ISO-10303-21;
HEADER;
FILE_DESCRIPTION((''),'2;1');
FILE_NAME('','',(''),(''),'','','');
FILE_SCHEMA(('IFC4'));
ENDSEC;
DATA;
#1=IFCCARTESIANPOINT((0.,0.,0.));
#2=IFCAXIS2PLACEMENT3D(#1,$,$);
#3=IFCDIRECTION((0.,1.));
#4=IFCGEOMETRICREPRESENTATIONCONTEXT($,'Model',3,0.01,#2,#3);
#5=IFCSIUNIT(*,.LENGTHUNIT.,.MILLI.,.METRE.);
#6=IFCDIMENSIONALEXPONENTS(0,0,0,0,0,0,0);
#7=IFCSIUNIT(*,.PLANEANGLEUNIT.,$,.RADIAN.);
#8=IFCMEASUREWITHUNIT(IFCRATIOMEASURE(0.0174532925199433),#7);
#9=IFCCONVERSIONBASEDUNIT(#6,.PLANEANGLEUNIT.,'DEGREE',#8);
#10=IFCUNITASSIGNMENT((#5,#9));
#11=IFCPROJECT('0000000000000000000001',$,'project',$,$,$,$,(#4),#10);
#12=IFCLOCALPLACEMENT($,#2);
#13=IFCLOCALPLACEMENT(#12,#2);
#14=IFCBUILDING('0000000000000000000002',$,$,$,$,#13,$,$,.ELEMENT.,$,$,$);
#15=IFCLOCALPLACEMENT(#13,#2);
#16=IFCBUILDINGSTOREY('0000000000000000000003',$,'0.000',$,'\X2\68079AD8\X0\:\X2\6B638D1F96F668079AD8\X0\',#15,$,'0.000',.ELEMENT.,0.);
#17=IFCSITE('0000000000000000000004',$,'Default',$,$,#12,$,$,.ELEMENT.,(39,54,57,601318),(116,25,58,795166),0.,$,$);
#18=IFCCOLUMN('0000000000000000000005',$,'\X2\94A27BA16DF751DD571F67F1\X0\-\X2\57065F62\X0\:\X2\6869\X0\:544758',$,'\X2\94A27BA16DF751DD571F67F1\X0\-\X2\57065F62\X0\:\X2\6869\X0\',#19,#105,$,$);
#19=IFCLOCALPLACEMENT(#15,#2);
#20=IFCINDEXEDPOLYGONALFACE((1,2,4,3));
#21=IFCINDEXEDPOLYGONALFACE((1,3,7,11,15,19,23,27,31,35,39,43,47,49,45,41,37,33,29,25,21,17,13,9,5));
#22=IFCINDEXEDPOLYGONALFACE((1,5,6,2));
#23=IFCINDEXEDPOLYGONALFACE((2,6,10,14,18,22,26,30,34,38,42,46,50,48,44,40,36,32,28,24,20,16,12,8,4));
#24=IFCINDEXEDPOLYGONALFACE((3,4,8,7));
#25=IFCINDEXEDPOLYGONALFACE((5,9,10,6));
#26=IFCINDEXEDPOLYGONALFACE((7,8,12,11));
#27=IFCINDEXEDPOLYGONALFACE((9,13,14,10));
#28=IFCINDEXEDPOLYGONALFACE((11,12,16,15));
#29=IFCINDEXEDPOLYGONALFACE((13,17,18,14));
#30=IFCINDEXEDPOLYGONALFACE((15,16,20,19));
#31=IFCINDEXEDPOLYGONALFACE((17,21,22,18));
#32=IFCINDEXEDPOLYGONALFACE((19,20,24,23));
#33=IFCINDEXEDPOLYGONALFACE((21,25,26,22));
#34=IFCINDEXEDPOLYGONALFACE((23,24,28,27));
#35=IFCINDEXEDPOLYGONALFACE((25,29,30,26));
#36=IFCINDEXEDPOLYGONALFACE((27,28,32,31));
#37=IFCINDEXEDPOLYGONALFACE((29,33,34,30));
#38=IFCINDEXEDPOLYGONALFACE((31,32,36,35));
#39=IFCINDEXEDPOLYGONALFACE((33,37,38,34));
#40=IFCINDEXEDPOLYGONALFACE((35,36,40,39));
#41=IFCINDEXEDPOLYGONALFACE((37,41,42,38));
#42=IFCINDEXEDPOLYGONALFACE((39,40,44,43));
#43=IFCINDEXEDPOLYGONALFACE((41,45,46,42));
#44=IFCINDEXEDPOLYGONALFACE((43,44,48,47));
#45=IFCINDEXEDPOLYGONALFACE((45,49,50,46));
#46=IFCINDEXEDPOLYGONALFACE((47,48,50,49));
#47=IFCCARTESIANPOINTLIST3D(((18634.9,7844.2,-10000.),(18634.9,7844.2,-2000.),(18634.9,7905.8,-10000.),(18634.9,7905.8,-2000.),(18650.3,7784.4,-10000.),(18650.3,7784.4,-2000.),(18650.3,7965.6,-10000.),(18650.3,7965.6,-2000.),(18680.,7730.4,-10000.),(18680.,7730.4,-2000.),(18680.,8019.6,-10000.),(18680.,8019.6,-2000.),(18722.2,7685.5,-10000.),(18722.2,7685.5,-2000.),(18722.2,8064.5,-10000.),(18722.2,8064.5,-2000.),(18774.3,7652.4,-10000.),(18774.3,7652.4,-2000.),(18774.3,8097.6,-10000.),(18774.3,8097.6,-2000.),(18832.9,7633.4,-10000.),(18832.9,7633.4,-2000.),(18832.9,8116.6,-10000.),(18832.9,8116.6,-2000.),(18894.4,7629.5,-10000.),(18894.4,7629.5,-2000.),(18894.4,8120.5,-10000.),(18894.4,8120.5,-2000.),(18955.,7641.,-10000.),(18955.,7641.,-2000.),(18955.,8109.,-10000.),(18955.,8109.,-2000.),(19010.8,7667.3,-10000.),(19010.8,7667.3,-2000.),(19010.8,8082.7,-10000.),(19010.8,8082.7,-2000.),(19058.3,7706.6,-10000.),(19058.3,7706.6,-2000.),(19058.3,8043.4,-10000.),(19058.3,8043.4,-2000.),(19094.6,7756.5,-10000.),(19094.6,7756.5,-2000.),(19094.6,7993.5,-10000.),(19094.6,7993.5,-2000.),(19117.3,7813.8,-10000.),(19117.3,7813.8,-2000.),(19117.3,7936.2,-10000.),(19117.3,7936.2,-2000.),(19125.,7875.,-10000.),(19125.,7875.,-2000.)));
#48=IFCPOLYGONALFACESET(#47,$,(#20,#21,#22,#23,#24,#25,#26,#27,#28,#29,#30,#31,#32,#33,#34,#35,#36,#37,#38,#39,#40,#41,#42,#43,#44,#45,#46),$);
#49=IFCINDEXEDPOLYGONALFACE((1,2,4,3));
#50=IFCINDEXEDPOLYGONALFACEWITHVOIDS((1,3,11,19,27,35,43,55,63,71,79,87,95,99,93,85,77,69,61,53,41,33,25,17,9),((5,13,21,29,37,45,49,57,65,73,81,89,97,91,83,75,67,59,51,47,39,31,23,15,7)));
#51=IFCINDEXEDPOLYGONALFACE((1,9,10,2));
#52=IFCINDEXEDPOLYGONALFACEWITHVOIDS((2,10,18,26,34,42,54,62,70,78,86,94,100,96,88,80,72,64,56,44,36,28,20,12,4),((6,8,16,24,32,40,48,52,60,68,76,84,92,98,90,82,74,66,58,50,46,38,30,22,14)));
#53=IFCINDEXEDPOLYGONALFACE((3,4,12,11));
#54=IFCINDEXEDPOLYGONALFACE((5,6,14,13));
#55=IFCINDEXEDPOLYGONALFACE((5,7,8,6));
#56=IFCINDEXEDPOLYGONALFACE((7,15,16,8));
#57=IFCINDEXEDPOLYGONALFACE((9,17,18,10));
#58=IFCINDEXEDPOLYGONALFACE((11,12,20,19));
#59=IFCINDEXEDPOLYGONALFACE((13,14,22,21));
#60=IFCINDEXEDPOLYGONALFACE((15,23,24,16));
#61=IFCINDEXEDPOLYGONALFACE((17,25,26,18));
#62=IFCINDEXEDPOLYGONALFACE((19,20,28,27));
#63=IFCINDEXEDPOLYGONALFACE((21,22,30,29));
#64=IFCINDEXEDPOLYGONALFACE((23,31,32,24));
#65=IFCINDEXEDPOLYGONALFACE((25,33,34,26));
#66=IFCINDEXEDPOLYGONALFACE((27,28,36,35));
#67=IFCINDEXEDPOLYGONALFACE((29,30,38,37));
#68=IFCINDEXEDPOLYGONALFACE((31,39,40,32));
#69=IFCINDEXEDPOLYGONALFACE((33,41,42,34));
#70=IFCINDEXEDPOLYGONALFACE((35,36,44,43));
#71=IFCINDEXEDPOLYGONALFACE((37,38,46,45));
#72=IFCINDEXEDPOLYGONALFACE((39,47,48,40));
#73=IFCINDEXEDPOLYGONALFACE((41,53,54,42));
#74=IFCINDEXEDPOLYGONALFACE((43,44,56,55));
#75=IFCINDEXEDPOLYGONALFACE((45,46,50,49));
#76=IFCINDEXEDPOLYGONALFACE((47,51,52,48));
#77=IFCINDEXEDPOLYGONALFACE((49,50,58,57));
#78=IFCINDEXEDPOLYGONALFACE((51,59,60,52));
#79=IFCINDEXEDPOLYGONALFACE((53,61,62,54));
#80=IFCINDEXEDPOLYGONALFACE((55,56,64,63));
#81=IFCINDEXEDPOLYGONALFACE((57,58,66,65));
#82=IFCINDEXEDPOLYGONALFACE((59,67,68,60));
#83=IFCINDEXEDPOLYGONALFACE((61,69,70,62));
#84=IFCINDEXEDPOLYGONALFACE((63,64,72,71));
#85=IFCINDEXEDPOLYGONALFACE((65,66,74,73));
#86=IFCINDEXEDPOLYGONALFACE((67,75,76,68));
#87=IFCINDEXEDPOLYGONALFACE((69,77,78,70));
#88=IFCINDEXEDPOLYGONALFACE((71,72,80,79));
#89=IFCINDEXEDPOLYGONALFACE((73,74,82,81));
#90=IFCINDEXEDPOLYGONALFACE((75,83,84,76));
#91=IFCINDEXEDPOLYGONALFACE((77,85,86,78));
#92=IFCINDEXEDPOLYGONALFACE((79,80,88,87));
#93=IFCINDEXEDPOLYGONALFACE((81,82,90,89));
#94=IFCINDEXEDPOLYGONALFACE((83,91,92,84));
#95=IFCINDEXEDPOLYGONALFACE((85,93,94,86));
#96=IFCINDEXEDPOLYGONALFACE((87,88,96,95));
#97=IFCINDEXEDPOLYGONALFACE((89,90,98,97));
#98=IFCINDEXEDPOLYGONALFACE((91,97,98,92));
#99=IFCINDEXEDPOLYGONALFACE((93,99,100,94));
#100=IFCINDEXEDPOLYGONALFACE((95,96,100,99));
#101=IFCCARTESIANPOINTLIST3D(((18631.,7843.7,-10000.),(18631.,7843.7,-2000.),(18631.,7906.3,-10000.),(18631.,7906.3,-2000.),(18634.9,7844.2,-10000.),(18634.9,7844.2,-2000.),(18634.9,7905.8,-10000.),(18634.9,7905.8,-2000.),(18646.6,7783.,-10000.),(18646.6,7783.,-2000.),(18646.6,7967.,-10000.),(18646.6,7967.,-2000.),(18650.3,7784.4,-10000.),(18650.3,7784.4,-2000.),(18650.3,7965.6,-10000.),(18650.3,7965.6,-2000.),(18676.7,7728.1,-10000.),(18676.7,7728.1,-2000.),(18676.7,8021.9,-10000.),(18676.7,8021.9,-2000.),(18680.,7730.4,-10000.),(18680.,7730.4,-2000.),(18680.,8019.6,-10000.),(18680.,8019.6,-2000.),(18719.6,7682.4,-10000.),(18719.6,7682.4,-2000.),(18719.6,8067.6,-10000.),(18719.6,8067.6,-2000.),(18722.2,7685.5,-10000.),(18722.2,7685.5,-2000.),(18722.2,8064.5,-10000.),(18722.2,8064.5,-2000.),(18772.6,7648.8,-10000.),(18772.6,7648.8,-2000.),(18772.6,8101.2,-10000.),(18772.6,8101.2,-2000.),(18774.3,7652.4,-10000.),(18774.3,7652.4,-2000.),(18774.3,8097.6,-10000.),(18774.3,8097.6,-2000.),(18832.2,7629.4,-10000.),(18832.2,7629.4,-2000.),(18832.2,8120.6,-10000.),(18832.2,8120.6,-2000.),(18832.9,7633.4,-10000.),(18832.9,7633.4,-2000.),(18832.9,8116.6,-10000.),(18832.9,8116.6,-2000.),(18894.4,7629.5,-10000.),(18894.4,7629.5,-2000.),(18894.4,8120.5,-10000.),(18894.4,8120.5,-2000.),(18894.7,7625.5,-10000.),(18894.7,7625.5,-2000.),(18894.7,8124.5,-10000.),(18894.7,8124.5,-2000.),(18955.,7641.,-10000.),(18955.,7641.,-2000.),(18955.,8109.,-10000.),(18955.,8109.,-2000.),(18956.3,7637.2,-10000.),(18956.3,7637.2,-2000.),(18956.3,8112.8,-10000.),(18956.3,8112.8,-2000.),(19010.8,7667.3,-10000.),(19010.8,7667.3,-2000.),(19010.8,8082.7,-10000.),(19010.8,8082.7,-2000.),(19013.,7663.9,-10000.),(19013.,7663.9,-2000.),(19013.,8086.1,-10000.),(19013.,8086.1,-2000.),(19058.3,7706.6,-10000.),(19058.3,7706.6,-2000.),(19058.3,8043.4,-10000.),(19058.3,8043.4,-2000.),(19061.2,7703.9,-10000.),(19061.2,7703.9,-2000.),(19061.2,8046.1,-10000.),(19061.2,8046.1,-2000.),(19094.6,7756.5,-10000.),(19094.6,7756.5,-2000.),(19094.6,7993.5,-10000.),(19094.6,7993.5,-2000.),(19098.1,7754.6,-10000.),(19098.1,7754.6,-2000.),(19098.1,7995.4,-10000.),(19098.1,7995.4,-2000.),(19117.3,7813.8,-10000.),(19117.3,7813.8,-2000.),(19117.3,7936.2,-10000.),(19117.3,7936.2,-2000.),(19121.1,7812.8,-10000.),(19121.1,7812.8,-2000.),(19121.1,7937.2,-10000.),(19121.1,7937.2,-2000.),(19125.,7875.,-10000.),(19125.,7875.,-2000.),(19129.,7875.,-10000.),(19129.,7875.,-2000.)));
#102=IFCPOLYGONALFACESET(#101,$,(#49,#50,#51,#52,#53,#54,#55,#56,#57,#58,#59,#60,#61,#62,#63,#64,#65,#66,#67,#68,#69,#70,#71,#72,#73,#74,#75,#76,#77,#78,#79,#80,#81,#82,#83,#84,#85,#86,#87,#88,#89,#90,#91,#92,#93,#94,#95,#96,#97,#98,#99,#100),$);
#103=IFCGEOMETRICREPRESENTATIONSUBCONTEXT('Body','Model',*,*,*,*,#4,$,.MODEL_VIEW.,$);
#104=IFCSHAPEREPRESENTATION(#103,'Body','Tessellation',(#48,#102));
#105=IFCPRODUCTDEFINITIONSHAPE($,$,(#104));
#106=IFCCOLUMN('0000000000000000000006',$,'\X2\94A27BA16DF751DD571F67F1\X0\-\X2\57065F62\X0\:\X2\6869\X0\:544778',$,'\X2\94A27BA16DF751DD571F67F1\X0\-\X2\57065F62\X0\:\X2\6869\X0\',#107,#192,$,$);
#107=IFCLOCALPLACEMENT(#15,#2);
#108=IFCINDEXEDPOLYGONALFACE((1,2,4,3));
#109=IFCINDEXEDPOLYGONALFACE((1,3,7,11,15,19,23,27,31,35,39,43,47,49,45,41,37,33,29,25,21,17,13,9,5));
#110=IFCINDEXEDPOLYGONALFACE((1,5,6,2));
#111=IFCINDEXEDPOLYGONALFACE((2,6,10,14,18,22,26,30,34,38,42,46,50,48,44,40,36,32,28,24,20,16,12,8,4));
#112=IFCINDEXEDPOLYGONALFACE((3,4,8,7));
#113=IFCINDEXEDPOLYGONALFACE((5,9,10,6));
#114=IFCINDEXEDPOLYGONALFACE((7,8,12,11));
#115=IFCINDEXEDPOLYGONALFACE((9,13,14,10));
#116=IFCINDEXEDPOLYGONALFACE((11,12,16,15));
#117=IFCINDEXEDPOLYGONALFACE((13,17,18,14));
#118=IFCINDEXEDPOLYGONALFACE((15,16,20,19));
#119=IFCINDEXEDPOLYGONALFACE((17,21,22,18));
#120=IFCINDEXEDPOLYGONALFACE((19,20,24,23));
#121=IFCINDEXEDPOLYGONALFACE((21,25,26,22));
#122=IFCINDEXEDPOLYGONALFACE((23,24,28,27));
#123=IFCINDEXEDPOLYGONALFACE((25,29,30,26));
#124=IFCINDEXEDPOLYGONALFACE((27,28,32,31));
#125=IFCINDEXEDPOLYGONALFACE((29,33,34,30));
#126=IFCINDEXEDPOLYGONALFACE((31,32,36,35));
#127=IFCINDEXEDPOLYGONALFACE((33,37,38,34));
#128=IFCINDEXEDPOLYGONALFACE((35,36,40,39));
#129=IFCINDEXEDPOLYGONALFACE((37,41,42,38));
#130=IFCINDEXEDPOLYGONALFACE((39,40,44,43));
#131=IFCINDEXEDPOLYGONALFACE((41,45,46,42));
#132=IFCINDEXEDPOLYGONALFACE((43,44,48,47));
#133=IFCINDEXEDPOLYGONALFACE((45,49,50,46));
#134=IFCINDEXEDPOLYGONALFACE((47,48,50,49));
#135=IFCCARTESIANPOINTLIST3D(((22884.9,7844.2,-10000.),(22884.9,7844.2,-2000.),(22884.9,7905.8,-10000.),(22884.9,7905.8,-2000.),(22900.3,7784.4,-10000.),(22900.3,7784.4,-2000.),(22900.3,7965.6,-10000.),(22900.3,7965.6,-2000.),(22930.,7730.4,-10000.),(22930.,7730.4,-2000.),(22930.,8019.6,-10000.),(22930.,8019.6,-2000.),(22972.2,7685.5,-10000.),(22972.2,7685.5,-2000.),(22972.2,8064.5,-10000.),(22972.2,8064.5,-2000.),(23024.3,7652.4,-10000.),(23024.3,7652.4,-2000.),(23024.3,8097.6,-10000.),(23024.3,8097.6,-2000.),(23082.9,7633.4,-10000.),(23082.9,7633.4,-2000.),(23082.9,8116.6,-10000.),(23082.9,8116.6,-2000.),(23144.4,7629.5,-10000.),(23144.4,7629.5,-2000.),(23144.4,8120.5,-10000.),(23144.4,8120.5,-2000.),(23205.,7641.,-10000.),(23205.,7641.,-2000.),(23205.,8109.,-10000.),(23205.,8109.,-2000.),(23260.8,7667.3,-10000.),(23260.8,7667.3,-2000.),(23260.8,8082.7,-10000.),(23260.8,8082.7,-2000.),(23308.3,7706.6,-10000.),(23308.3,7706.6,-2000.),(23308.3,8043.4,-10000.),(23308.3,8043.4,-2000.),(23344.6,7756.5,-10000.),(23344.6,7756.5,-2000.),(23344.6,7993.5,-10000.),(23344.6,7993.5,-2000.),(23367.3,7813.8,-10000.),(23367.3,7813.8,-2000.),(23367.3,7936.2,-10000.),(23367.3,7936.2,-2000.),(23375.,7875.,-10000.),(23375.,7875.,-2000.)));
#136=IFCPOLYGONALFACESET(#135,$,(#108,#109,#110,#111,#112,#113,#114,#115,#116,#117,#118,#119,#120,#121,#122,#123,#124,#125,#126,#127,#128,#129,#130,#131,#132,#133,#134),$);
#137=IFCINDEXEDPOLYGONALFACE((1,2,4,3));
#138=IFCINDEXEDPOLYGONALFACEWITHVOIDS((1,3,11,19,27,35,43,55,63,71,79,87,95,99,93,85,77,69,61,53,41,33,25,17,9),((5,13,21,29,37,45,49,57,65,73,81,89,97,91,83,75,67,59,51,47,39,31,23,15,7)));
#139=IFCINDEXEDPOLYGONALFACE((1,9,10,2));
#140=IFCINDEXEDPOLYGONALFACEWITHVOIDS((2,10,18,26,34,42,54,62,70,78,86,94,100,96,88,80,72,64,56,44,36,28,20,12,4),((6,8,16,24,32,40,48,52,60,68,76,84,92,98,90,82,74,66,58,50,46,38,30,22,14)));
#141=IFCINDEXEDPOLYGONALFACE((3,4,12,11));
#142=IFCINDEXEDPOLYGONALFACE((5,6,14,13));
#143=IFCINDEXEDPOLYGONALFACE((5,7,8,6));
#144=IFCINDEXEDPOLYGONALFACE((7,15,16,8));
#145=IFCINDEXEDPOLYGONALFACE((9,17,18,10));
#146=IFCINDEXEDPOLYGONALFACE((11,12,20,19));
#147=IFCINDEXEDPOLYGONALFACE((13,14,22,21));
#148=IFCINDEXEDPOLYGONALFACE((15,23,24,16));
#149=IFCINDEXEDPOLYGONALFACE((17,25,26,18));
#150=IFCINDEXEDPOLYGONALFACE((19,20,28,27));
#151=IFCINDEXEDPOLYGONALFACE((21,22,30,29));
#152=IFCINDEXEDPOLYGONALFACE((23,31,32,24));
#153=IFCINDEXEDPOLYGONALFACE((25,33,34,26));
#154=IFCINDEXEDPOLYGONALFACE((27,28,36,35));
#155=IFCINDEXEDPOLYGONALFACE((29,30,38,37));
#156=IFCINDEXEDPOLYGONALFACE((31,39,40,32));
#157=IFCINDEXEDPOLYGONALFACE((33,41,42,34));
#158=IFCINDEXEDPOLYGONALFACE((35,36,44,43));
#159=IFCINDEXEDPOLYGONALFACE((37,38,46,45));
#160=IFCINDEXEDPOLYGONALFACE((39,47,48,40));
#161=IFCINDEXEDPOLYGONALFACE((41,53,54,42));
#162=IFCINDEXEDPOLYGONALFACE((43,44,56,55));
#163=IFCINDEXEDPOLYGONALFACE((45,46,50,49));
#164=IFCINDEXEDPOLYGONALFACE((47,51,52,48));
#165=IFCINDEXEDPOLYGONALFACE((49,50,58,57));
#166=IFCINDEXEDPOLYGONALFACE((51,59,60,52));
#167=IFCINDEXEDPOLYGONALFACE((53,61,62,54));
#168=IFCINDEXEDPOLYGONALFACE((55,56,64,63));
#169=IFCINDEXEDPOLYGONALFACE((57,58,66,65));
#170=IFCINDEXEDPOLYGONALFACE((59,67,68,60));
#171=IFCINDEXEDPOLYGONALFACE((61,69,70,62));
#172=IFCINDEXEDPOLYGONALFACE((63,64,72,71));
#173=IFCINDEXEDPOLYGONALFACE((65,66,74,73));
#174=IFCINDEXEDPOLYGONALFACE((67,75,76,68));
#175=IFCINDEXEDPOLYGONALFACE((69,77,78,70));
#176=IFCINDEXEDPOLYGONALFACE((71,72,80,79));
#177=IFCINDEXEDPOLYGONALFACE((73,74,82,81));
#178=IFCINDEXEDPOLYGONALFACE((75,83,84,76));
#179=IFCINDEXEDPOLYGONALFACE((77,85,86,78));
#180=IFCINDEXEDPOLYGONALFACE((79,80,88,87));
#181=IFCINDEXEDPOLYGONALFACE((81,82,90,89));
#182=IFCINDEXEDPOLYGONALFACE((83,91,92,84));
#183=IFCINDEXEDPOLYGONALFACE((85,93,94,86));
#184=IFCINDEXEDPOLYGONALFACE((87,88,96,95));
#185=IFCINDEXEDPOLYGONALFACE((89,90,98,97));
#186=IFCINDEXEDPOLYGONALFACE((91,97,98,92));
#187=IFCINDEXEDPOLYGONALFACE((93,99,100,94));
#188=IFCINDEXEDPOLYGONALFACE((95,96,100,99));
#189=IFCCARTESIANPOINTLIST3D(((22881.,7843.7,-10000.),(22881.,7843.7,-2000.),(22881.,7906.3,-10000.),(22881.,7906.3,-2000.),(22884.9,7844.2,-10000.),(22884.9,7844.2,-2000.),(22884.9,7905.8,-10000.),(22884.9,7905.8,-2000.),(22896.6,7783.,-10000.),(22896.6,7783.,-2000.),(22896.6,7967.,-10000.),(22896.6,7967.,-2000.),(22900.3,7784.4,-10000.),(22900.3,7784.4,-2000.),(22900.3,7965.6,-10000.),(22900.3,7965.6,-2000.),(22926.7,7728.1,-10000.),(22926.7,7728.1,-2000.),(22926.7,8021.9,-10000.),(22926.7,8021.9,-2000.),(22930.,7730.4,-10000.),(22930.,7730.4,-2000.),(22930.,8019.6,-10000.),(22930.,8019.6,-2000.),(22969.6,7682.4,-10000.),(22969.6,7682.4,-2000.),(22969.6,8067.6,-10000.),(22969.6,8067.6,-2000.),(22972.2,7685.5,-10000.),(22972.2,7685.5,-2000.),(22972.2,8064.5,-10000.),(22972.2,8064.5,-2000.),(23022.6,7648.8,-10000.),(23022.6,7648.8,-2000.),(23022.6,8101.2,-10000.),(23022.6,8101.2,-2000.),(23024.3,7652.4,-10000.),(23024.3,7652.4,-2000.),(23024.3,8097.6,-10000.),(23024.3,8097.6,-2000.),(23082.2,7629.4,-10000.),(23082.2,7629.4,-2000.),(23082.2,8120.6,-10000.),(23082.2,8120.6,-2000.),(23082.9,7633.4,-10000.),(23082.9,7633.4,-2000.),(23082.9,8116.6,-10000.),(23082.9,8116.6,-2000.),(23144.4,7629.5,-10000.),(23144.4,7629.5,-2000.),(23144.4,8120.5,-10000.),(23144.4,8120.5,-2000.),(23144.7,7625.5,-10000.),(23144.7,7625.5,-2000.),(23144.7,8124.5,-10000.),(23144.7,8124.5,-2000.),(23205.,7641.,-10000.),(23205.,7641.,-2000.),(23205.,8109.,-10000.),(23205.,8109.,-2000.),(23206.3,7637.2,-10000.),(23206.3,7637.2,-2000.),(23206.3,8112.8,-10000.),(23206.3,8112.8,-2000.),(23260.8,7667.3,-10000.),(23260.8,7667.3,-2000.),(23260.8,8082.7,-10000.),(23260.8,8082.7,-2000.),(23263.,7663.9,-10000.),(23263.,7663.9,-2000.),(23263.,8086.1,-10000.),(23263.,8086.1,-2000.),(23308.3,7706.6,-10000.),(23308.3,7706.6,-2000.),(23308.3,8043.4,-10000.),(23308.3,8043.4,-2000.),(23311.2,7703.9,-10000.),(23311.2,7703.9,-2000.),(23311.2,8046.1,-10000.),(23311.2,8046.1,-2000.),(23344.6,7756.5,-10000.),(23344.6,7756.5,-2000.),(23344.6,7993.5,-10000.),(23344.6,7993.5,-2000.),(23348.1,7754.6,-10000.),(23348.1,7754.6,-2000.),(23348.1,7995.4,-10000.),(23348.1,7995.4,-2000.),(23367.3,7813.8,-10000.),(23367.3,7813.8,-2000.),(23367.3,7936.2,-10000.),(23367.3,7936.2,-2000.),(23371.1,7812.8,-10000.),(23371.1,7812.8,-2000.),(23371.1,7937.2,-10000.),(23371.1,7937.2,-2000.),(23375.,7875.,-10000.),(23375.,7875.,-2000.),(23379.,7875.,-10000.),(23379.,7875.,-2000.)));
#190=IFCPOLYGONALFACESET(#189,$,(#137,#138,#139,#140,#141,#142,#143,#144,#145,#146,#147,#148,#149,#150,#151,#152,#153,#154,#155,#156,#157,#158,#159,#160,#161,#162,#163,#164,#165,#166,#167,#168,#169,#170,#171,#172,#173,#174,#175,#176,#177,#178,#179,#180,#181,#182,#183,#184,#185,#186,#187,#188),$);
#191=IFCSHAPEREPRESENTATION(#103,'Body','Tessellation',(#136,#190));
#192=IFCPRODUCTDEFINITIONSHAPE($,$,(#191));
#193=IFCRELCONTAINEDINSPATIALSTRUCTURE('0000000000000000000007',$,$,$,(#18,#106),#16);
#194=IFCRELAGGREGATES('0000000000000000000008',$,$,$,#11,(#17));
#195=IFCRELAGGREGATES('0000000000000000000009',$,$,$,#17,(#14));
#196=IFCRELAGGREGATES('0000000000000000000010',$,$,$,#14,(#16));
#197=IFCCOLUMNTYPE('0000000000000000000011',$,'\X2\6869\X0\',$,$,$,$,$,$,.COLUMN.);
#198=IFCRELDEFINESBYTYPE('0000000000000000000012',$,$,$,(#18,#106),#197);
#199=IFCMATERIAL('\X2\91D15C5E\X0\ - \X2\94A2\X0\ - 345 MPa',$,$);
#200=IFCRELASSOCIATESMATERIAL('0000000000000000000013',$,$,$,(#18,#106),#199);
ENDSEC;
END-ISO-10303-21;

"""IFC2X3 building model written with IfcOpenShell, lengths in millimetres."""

from ifc_helpers import new_model, entity, si_unit, converted_unit, direction, frame, frame_2d, origin, place, context, subcontext, project, spatial, circle, hollow_circle, extrude, source, transform, mapped, material, type_object, type_shapes, element, save


model = new_model("IFC2X3")

# Units and contexts
model_context = context("Model", 3, precision=0.01, world=origin(), true_north=direction((0.0, 1.0)))
body_context = subcontext(model_context, "Body", "Model", "MODEL_VIEW")
ifc_project = project(units=[si_unit("LENGTHUNIT", "METRE", prefix="MILLI"), converted_unit("PLANEANGLEUNIT", "DEGREE", entity("IfcRatioMeasure", 0.0174532925199433), si_unit("PLANEANGLEUNIT", "RADIAN"), dimensions=[0, 0, 0, 0, 0, 0, 0])], contexts=[model_context])

# Site, building, storey
site_placement = place(None, origin())
site = spatial("IfcSite", under=ifc_project, at=site_placement, Name="Default", CompositionType="ELEMENT", RefLatitude=(39, 54, 57, 601318), RefLongitude=(116, 25, 58, 795166), RefElevation=0.0)
building_placement = place(site_placement, origin())
building = spatial("IfcBuilding", under=site, at=building_placement, CompositionType="ELEMENT")
storey_placement = place(building_placement, origin())
storey = spatial("IfcBuildingStorey", under=building, at=storey_placement, Name="0.000", ObjectType="标高:正负零标高", LongName="0.000", CompositionType="ELEMENT", Elevation=0.0)

# Columns
ifc_material_1 = material(Name="金属 - 钢 - 345 MPa")
column_type = type_object("IfcColumnType", Name="桩", PredefinedType="COLUMN")
shared_shape = source(origin(), body_context, "Body", "SweptSolid", [
    extrude(circle(Radius=246.0, at=frame_2d((0.0, 0.0), x_axis=(1.0, 0.0))), frame((0.0, 0.0, -10000.0)), (0.0, 0.0, 1.0), 8000.0),
    extrude(hollow_circle(Radius=250.0, WallThickness=4.0, at=frame_2d((0.0, 0.0), x_axis=(1.0, 0.0))), frame((0.0, 0.0, -10000.0)), (0.0, 0.0, 1.0), 8000.0),
])
type_shapes(column_type, [shared_shape])
for number, where, name in (
    (1, (18879.0, 7875.0, 0.0), "钢管混凝土柱-圆形:桩:544758"),
    (2, (23129.0, 7875.0, 0.0), "钢管混凝土柱-圆形:桩:544778"),
):
    element("IfcColumn", number, at=place(storey_placement, frame(where)), inside=storey, type_object=column_type, material=ifc_material_1, Name=name, ObjectType="钢管混凝土柱-圆形:桩", context=body_context, shape_type="MappedRepresentation", body=[
        mapped(shared_shape, transform((0.0, 0.0, 0.0), scale=1.0)),
    ])

save(model, "model.ifc")
